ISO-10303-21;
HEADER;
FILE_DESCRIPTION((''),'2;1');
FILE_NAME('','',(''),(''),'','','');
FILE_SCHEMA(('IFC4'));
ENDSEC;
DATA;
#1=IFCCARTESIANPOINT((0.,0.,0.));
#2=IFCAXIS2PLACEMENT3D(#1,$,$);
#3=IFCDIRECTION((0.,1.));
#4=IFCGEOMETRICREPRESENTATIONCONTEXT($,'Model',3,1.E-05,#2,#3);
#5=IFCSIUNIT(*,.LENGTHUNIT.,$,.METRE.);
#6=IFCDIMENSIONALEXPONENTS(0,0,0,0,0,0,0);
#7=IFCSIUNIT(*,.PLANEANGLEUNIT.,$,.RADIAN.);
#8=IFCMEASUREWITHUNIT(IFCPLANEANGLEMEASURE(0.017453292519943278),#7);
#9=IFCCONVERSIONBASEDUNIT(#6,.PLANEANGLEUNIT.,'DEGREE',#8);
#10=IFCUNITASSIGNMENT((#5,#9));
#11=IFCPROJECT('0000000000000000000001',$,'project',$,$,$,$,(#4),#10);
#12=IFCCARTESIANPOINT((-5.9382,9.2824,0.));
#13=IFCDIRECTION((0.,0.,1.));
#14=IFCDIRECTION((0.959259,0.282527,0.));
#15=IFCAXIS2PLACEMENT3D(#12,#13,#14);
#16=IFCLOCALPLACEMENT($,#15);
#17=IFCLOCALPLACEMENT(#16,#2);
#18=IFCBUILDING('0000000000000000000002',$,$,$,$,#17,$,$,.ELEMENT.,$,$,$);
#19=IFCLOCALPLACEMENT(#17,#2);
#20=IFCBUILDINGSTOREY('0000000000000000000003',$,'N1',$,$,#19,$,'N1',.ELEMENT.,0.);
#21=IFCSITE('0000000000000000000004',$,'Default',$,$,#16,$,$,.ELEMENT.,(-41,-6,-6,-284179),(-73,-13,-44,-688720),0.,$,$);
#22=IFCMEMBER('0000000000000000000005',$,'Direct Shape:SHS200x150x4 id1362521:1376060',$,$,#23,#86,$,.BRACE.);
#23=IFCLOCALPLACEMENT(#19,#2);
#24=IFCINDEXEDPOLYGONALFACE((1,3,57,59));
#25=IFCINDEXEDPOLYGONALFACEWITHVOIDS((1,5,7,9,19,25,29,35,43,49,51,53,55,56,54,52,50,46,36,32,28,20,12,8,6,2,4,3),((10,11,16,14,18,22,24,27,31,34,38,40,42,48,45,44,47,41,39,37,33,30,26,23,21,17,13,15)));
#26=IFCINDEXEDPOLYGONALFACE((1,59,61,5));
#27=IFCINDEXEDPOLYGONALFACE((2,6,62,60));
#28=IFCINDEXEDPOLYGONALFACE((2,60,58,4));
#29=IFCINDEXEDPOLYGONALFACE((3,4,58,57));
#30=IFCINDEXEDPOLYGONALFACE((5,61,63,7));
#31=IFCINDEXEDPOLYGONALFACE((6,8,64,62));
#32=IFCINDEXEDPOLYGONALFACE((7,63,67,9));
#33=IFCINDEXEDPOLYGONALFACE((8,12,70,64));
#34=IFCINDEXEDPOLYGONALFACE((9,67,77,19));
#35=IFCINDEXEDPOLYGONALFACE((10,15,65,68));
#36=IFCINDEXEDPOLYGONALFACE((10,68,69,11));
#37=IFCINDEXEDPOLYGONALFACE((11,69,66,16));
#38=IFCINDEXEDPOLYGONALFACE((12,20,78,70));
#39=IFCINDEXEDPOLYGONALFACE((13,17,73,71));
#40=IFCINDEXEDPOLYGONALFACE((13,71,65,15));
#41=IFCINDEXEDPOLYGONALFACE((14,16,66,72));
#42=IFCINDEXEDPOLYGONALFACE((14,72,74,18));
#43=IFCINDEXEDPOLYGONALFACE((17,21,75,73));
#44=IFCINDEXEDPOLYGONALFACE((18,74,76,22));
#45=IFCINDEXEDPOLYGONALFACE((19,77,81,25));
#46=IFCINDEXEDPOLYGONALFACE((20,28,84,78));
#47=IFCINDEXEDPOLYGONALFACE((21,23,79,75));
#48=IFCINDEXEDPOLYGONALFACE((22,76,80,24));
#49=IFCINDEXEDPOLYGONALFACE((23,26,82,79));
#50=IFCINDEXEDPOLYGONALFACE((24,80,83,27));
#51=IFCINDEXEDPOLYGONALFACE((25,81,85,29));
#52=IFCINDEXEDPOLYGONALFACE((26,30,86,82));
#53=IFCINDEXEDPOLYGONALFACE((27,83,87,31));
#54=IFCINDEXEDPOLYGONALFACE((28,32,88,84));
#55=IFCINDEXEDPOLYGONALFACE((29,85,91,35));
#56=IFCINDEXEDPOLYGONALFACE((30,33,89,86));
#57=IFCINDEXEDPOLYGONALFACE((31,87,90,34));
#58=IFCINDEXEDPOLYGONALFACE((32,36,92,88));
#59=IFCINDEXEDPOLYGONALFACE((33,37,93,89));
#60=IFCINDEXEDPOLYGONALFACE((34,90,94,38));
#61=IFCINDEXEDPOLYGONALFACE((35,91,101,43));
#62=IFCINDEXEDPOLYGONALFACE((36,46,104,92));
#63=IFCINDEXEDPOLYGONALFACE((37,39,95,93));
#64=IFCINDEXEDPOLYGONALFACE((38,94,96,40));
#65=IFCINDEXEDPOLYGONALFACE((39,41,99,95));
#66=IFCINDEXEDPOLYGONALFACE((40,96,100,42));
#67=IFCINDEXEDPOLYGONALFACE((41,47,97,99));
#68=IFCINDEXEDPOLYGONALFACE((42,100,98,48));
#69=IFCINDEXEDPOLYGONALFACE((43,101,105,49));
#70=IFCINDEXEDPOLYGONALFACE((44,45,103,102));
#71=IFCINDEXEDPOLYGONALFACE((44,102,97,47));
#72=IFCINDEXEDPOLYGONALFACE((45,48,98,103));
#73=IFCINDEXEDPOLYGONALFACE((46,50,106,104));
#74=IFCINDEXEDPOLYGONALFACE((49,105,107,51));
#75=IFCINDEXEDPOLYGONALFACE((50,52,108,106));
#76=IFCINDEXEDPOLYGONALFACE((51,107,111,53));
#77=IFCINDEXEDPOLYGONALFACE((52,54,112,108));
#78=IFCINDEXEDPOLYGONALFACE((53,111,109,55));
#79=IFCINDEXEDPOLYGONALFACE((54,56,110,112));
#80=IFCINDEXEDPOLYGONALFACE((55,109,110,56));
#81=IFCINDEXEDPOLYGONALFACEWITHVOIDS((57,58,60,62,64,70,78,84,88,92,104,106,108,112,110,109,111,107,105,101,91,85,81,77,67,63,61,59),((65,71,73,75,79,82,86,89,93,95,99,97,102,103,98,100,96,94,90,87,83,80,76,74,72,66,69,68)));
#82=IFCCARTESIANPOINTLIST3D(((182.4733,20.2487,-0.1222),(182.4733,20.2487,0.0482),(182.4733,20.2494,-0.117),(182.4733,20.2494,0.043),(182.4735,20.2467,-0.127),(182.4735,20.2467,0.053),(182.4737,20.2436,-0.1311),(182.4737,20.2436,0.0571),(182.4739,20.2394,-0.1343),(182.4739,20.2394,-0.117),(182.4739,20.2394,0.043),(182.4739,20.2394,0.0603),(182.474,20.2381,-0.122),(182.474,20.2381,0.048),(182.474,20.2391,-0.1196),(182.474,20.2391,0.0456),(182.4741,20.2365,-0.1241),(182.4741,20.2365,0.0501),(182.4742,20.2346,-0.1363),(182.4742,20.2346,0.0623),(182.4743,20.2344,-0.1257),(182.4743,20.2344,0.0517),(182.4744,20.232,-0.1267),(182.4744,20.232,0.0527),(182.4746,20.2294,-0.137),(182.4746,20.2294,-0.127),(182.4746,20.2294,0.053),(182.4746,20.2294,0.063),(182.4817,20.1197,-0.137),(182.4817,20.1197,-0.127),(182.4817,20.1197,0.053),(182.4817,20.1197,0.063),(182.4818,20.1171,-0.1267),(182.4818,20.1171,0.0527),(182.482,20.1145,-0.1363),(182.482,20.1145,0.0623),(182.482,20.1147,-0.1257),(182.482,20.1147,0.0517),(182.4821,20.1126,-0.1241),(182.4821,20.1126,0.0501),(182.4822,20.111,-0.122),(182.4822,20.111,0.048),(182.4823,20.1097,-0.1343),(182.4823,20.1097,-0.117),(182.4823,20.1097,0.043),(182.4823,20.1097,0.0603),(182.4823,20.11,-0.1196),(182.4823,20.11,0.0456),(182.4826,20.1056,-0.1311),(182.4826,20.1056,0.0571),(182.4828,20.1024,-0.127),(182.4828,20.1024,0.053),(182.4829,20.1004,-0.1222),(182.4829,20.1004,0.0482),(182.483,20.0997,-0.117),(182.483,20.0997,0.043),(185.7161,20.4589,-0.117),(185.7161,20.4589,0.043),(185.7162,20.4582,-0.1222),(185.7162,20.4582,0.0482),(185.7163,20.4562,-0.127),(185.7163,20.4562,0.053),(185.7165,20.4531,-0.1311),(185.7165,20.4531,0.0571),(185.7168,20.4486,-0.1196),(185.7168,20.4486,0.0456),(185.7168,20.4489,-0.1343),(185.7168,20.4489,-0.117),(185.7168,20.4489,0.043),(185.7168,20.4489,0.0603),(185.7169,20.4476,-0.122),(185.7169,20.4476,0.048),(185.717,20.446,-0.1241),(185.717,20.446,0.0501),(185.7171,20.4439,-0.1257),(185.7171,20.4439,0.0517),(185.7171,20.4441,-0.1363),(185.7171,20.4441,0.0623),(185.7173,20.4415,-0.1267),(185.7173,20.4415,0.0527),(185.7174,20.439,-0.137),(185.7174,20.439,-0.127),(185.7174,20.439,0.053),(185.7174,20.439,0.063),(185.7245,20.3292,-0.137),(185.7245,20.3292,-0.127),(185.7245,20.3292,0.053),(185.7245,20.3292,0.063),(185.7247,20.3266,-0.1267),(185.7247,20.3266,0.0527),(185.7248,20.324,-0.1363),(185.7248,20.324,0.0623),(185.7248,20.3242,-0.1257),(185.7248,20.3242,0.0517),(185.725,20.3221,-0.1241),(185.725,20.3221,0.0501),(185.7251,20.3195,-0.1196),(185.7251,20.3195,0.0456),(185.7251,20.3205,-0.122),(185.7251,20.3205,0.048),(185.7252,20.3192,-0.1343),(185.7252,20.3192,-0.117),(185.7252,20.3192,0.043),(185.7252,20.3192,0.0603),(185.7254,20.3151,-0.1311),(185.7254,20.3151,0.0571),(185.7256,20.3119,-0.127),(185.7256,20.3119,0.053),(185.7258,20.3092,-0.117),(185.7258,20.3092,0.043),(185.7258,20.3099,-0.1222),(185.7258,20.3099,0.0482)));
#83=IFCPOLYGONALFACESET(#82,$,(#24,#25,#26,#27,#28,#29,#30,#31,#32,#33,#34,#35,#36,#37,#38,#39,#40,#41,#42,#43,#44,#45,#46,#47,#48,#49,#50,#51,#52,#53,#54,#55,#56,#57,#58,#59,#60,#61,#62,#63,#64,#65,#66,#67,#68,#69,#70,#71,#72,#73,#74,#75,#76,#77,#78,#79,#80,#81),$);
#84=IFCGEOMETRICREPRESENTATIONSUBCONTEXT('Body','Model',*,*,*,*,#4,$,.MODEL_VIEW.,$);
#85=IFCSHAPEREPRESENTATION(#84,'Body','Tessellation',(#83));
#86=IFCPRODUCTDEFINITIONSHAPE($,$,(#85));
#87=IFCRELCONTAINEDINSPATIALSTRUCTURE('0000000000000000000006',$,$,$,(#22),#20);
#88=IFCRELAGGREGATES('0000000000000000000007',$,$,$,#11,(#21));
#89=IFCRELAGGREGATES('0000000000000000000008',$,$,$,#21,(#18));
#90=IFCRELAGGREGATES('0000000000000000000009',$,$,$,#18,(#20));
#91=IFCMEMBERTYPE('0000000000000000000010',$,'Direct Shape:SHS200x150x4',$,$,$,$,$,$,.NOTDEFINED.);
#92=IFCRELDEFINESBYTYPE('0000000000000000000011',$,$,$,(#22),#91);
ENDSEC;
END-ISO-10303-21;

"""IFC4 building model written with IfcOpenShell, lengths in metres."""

from ifc_helpers import new_model, entity, si_unit, converted_unit, direction, frame, frame_2d, origin, place, context, subcontext, project, spatial, polyline, circle_curve, parameter, trimmed, segment, composite_curve, outline, extrude, type_object, element, save


model = new_model("IFC4")

# Units and contexts
model_context = context("Model", 3, precision=1e-05, world=origin(), true_north=direction((0.0, 1.0)))
body_context = subcontext(model_context, "Body", "Model", "MODEL_VIEW")
ifc_project = project(units=[si_unit("LENGTHUNIT", "METRE"), converted_unit("PLANEANGLEUNIT", "DEGREE", entity("IfcPlaneAngleMeasure", 0.017453292519943278), si_unit("PLANEANGLEUNIT", "RADIAN"), dimensions=[0, 0, 0, 0, 0, 0, 0])], contexts=[model_context])

# Site, building, storey
site_placement = place(None, frame((-5.9382, 9.2824, 0.0), z_axis=(0.0, 0.0, 1.0), x_axis=(0.959259, 0.282527, 0.0)))
site = spatial("IfcSite", under=ifc_project, at=site_placement, Name="Default", CompositionType="ELEMENT", RefLatitude=(-41, -6, -6, -284179), RefLongitude=(-73, -13, -44, -688720), RefElevation=0.0)
building_placement = place(site_placement, origin())
building = spatial("IfcBuilding", under=site, at=building_placement, CompositionType="ELEMENT")
storey_placement = place(building_placement, origin())
storey = spatial("IfcBuildingStorey", under=building, at=storey_placement, Name="N1", LongName="N1", CompositionType="ELEMENT", Elevation=0.0)

# Member
member_type_1 = type_object("IfcMemberType", Name="Direct Shape:SHS200x150x4", PredefinedType="NOTDEFINED")
member_1_placement = place(storey_placement, origin())
element("IfcMember", 1, at=member_1_placement, inside=storey, type_object=member_type_1, Name="Direct Shape:SHS200x150x4 id1362521:1376060", PredefinedType="BRACE", context=body_context, shape_type="SweptSolid", body=[
    extrude(outline(composite_curve([segment(polyline([(-0.08, -0.075), (0.08, -0.075)]), True, "CONTINUOUS"), segment(trimmed(circle_curve(frame_2d((0.08, -0.055), x_axis=(0.0, 1.0)), 0.02), [parameter(180.0)], [parameter(270.0)], True, "PARAMETER"), True, "CONTINUOUS"), segment(polyline([(0.1, -0.055), (0.1, 0.055)]), True, "CONTINUOUS"), segment(trimmed(circle_curve(frame_2d((0.08, 0.055), x_axis=(0.0, 1.0)), 0.02), [parameter(270.0)], [parameter(0.0)], True, "PARAMETER"), True, "CONTINUOUS"), segment(polyline([(0.08, 0.075), (-0.08, 0.075)]), True, "CONTINUOUS"), segment(trimmed(circle_curve(frame_2d((-0.08, 0.055), x_axis=(0.0, 1.0)), 0.02), [parameter(360.0)], [parameter(90.0)], True, "PARAMETER"), True, "CONTINUOUS"), segment(polyline([(-0.1, 0.055), (-0.1, -0.055)]), True, "CONTINUOUS"), segment(trimmed(circle_curve(frame_2d((-0.08, -0.055), x_axis=(0.0, 1.0)), 0.02), [parameter(90.0)], [parameter(180.0)], True, "PARAMETER"), True, "CONTINUOUS")], self_intersect=False), holes=[composite_curve([segment(trimmed(circle_curve(frame_2d((-0.08, 0.055), x_axis=(0.0, 1.0)), 0.01), [parameter(360.0)], [parameter(90.0)], True, "PARAMETER"), False, "CONTINUOUS"), segment(polyline([(-0.08, 0.065), (0.08, 0.065)]), True, "CONTINUOUS"), segment(trimmed(circle_curve(frame_2d((0.08, 0.055), x_axis=(0.0, 1.0)), 0.01), [parameter(270.0)], [parameter(0.0)], True, "PARAMETER"), False, "CONTINUOUS"), segment(polyline([(0.09, 0.055), (0.09, -0.055)]), True, "CONTINUOUS"), segment(trimmed(circle_curve(frame_2d((0.08, -0.055), x_axis=(0.0, 1.0)), 0.01), [parameter(180.0)], [parameter(270.0)], True, "PARAMETER"), False, "CONTINUOUS"), segment(polyline([(0.08, -0.065), (-0.08, -0.065)]), True, "CONTINUOUS"), segment(trimmed(circle_curve(frame_2d((-0.08, -0.055), x_axis=(0.0, 1.0)), 0.01), [parameter(90.0)], [parameter(180.0)], True, "PARAMETER"), False, "CONTINUOUS"), segment(polyline([(-0.09, -0.055), (-0.09, 0.055)]), True, "CONTINUOUS")], self_intersect=False)]), frame((182.4781, 20.1746, -0.037), z_axis=(0.99792, 0.064471, 0.0), x_axis=(0.0, 0.0, -1.0)), (0.0, 0.0, 1.0), 3.2496),
])

save(model, "model.ifc")
